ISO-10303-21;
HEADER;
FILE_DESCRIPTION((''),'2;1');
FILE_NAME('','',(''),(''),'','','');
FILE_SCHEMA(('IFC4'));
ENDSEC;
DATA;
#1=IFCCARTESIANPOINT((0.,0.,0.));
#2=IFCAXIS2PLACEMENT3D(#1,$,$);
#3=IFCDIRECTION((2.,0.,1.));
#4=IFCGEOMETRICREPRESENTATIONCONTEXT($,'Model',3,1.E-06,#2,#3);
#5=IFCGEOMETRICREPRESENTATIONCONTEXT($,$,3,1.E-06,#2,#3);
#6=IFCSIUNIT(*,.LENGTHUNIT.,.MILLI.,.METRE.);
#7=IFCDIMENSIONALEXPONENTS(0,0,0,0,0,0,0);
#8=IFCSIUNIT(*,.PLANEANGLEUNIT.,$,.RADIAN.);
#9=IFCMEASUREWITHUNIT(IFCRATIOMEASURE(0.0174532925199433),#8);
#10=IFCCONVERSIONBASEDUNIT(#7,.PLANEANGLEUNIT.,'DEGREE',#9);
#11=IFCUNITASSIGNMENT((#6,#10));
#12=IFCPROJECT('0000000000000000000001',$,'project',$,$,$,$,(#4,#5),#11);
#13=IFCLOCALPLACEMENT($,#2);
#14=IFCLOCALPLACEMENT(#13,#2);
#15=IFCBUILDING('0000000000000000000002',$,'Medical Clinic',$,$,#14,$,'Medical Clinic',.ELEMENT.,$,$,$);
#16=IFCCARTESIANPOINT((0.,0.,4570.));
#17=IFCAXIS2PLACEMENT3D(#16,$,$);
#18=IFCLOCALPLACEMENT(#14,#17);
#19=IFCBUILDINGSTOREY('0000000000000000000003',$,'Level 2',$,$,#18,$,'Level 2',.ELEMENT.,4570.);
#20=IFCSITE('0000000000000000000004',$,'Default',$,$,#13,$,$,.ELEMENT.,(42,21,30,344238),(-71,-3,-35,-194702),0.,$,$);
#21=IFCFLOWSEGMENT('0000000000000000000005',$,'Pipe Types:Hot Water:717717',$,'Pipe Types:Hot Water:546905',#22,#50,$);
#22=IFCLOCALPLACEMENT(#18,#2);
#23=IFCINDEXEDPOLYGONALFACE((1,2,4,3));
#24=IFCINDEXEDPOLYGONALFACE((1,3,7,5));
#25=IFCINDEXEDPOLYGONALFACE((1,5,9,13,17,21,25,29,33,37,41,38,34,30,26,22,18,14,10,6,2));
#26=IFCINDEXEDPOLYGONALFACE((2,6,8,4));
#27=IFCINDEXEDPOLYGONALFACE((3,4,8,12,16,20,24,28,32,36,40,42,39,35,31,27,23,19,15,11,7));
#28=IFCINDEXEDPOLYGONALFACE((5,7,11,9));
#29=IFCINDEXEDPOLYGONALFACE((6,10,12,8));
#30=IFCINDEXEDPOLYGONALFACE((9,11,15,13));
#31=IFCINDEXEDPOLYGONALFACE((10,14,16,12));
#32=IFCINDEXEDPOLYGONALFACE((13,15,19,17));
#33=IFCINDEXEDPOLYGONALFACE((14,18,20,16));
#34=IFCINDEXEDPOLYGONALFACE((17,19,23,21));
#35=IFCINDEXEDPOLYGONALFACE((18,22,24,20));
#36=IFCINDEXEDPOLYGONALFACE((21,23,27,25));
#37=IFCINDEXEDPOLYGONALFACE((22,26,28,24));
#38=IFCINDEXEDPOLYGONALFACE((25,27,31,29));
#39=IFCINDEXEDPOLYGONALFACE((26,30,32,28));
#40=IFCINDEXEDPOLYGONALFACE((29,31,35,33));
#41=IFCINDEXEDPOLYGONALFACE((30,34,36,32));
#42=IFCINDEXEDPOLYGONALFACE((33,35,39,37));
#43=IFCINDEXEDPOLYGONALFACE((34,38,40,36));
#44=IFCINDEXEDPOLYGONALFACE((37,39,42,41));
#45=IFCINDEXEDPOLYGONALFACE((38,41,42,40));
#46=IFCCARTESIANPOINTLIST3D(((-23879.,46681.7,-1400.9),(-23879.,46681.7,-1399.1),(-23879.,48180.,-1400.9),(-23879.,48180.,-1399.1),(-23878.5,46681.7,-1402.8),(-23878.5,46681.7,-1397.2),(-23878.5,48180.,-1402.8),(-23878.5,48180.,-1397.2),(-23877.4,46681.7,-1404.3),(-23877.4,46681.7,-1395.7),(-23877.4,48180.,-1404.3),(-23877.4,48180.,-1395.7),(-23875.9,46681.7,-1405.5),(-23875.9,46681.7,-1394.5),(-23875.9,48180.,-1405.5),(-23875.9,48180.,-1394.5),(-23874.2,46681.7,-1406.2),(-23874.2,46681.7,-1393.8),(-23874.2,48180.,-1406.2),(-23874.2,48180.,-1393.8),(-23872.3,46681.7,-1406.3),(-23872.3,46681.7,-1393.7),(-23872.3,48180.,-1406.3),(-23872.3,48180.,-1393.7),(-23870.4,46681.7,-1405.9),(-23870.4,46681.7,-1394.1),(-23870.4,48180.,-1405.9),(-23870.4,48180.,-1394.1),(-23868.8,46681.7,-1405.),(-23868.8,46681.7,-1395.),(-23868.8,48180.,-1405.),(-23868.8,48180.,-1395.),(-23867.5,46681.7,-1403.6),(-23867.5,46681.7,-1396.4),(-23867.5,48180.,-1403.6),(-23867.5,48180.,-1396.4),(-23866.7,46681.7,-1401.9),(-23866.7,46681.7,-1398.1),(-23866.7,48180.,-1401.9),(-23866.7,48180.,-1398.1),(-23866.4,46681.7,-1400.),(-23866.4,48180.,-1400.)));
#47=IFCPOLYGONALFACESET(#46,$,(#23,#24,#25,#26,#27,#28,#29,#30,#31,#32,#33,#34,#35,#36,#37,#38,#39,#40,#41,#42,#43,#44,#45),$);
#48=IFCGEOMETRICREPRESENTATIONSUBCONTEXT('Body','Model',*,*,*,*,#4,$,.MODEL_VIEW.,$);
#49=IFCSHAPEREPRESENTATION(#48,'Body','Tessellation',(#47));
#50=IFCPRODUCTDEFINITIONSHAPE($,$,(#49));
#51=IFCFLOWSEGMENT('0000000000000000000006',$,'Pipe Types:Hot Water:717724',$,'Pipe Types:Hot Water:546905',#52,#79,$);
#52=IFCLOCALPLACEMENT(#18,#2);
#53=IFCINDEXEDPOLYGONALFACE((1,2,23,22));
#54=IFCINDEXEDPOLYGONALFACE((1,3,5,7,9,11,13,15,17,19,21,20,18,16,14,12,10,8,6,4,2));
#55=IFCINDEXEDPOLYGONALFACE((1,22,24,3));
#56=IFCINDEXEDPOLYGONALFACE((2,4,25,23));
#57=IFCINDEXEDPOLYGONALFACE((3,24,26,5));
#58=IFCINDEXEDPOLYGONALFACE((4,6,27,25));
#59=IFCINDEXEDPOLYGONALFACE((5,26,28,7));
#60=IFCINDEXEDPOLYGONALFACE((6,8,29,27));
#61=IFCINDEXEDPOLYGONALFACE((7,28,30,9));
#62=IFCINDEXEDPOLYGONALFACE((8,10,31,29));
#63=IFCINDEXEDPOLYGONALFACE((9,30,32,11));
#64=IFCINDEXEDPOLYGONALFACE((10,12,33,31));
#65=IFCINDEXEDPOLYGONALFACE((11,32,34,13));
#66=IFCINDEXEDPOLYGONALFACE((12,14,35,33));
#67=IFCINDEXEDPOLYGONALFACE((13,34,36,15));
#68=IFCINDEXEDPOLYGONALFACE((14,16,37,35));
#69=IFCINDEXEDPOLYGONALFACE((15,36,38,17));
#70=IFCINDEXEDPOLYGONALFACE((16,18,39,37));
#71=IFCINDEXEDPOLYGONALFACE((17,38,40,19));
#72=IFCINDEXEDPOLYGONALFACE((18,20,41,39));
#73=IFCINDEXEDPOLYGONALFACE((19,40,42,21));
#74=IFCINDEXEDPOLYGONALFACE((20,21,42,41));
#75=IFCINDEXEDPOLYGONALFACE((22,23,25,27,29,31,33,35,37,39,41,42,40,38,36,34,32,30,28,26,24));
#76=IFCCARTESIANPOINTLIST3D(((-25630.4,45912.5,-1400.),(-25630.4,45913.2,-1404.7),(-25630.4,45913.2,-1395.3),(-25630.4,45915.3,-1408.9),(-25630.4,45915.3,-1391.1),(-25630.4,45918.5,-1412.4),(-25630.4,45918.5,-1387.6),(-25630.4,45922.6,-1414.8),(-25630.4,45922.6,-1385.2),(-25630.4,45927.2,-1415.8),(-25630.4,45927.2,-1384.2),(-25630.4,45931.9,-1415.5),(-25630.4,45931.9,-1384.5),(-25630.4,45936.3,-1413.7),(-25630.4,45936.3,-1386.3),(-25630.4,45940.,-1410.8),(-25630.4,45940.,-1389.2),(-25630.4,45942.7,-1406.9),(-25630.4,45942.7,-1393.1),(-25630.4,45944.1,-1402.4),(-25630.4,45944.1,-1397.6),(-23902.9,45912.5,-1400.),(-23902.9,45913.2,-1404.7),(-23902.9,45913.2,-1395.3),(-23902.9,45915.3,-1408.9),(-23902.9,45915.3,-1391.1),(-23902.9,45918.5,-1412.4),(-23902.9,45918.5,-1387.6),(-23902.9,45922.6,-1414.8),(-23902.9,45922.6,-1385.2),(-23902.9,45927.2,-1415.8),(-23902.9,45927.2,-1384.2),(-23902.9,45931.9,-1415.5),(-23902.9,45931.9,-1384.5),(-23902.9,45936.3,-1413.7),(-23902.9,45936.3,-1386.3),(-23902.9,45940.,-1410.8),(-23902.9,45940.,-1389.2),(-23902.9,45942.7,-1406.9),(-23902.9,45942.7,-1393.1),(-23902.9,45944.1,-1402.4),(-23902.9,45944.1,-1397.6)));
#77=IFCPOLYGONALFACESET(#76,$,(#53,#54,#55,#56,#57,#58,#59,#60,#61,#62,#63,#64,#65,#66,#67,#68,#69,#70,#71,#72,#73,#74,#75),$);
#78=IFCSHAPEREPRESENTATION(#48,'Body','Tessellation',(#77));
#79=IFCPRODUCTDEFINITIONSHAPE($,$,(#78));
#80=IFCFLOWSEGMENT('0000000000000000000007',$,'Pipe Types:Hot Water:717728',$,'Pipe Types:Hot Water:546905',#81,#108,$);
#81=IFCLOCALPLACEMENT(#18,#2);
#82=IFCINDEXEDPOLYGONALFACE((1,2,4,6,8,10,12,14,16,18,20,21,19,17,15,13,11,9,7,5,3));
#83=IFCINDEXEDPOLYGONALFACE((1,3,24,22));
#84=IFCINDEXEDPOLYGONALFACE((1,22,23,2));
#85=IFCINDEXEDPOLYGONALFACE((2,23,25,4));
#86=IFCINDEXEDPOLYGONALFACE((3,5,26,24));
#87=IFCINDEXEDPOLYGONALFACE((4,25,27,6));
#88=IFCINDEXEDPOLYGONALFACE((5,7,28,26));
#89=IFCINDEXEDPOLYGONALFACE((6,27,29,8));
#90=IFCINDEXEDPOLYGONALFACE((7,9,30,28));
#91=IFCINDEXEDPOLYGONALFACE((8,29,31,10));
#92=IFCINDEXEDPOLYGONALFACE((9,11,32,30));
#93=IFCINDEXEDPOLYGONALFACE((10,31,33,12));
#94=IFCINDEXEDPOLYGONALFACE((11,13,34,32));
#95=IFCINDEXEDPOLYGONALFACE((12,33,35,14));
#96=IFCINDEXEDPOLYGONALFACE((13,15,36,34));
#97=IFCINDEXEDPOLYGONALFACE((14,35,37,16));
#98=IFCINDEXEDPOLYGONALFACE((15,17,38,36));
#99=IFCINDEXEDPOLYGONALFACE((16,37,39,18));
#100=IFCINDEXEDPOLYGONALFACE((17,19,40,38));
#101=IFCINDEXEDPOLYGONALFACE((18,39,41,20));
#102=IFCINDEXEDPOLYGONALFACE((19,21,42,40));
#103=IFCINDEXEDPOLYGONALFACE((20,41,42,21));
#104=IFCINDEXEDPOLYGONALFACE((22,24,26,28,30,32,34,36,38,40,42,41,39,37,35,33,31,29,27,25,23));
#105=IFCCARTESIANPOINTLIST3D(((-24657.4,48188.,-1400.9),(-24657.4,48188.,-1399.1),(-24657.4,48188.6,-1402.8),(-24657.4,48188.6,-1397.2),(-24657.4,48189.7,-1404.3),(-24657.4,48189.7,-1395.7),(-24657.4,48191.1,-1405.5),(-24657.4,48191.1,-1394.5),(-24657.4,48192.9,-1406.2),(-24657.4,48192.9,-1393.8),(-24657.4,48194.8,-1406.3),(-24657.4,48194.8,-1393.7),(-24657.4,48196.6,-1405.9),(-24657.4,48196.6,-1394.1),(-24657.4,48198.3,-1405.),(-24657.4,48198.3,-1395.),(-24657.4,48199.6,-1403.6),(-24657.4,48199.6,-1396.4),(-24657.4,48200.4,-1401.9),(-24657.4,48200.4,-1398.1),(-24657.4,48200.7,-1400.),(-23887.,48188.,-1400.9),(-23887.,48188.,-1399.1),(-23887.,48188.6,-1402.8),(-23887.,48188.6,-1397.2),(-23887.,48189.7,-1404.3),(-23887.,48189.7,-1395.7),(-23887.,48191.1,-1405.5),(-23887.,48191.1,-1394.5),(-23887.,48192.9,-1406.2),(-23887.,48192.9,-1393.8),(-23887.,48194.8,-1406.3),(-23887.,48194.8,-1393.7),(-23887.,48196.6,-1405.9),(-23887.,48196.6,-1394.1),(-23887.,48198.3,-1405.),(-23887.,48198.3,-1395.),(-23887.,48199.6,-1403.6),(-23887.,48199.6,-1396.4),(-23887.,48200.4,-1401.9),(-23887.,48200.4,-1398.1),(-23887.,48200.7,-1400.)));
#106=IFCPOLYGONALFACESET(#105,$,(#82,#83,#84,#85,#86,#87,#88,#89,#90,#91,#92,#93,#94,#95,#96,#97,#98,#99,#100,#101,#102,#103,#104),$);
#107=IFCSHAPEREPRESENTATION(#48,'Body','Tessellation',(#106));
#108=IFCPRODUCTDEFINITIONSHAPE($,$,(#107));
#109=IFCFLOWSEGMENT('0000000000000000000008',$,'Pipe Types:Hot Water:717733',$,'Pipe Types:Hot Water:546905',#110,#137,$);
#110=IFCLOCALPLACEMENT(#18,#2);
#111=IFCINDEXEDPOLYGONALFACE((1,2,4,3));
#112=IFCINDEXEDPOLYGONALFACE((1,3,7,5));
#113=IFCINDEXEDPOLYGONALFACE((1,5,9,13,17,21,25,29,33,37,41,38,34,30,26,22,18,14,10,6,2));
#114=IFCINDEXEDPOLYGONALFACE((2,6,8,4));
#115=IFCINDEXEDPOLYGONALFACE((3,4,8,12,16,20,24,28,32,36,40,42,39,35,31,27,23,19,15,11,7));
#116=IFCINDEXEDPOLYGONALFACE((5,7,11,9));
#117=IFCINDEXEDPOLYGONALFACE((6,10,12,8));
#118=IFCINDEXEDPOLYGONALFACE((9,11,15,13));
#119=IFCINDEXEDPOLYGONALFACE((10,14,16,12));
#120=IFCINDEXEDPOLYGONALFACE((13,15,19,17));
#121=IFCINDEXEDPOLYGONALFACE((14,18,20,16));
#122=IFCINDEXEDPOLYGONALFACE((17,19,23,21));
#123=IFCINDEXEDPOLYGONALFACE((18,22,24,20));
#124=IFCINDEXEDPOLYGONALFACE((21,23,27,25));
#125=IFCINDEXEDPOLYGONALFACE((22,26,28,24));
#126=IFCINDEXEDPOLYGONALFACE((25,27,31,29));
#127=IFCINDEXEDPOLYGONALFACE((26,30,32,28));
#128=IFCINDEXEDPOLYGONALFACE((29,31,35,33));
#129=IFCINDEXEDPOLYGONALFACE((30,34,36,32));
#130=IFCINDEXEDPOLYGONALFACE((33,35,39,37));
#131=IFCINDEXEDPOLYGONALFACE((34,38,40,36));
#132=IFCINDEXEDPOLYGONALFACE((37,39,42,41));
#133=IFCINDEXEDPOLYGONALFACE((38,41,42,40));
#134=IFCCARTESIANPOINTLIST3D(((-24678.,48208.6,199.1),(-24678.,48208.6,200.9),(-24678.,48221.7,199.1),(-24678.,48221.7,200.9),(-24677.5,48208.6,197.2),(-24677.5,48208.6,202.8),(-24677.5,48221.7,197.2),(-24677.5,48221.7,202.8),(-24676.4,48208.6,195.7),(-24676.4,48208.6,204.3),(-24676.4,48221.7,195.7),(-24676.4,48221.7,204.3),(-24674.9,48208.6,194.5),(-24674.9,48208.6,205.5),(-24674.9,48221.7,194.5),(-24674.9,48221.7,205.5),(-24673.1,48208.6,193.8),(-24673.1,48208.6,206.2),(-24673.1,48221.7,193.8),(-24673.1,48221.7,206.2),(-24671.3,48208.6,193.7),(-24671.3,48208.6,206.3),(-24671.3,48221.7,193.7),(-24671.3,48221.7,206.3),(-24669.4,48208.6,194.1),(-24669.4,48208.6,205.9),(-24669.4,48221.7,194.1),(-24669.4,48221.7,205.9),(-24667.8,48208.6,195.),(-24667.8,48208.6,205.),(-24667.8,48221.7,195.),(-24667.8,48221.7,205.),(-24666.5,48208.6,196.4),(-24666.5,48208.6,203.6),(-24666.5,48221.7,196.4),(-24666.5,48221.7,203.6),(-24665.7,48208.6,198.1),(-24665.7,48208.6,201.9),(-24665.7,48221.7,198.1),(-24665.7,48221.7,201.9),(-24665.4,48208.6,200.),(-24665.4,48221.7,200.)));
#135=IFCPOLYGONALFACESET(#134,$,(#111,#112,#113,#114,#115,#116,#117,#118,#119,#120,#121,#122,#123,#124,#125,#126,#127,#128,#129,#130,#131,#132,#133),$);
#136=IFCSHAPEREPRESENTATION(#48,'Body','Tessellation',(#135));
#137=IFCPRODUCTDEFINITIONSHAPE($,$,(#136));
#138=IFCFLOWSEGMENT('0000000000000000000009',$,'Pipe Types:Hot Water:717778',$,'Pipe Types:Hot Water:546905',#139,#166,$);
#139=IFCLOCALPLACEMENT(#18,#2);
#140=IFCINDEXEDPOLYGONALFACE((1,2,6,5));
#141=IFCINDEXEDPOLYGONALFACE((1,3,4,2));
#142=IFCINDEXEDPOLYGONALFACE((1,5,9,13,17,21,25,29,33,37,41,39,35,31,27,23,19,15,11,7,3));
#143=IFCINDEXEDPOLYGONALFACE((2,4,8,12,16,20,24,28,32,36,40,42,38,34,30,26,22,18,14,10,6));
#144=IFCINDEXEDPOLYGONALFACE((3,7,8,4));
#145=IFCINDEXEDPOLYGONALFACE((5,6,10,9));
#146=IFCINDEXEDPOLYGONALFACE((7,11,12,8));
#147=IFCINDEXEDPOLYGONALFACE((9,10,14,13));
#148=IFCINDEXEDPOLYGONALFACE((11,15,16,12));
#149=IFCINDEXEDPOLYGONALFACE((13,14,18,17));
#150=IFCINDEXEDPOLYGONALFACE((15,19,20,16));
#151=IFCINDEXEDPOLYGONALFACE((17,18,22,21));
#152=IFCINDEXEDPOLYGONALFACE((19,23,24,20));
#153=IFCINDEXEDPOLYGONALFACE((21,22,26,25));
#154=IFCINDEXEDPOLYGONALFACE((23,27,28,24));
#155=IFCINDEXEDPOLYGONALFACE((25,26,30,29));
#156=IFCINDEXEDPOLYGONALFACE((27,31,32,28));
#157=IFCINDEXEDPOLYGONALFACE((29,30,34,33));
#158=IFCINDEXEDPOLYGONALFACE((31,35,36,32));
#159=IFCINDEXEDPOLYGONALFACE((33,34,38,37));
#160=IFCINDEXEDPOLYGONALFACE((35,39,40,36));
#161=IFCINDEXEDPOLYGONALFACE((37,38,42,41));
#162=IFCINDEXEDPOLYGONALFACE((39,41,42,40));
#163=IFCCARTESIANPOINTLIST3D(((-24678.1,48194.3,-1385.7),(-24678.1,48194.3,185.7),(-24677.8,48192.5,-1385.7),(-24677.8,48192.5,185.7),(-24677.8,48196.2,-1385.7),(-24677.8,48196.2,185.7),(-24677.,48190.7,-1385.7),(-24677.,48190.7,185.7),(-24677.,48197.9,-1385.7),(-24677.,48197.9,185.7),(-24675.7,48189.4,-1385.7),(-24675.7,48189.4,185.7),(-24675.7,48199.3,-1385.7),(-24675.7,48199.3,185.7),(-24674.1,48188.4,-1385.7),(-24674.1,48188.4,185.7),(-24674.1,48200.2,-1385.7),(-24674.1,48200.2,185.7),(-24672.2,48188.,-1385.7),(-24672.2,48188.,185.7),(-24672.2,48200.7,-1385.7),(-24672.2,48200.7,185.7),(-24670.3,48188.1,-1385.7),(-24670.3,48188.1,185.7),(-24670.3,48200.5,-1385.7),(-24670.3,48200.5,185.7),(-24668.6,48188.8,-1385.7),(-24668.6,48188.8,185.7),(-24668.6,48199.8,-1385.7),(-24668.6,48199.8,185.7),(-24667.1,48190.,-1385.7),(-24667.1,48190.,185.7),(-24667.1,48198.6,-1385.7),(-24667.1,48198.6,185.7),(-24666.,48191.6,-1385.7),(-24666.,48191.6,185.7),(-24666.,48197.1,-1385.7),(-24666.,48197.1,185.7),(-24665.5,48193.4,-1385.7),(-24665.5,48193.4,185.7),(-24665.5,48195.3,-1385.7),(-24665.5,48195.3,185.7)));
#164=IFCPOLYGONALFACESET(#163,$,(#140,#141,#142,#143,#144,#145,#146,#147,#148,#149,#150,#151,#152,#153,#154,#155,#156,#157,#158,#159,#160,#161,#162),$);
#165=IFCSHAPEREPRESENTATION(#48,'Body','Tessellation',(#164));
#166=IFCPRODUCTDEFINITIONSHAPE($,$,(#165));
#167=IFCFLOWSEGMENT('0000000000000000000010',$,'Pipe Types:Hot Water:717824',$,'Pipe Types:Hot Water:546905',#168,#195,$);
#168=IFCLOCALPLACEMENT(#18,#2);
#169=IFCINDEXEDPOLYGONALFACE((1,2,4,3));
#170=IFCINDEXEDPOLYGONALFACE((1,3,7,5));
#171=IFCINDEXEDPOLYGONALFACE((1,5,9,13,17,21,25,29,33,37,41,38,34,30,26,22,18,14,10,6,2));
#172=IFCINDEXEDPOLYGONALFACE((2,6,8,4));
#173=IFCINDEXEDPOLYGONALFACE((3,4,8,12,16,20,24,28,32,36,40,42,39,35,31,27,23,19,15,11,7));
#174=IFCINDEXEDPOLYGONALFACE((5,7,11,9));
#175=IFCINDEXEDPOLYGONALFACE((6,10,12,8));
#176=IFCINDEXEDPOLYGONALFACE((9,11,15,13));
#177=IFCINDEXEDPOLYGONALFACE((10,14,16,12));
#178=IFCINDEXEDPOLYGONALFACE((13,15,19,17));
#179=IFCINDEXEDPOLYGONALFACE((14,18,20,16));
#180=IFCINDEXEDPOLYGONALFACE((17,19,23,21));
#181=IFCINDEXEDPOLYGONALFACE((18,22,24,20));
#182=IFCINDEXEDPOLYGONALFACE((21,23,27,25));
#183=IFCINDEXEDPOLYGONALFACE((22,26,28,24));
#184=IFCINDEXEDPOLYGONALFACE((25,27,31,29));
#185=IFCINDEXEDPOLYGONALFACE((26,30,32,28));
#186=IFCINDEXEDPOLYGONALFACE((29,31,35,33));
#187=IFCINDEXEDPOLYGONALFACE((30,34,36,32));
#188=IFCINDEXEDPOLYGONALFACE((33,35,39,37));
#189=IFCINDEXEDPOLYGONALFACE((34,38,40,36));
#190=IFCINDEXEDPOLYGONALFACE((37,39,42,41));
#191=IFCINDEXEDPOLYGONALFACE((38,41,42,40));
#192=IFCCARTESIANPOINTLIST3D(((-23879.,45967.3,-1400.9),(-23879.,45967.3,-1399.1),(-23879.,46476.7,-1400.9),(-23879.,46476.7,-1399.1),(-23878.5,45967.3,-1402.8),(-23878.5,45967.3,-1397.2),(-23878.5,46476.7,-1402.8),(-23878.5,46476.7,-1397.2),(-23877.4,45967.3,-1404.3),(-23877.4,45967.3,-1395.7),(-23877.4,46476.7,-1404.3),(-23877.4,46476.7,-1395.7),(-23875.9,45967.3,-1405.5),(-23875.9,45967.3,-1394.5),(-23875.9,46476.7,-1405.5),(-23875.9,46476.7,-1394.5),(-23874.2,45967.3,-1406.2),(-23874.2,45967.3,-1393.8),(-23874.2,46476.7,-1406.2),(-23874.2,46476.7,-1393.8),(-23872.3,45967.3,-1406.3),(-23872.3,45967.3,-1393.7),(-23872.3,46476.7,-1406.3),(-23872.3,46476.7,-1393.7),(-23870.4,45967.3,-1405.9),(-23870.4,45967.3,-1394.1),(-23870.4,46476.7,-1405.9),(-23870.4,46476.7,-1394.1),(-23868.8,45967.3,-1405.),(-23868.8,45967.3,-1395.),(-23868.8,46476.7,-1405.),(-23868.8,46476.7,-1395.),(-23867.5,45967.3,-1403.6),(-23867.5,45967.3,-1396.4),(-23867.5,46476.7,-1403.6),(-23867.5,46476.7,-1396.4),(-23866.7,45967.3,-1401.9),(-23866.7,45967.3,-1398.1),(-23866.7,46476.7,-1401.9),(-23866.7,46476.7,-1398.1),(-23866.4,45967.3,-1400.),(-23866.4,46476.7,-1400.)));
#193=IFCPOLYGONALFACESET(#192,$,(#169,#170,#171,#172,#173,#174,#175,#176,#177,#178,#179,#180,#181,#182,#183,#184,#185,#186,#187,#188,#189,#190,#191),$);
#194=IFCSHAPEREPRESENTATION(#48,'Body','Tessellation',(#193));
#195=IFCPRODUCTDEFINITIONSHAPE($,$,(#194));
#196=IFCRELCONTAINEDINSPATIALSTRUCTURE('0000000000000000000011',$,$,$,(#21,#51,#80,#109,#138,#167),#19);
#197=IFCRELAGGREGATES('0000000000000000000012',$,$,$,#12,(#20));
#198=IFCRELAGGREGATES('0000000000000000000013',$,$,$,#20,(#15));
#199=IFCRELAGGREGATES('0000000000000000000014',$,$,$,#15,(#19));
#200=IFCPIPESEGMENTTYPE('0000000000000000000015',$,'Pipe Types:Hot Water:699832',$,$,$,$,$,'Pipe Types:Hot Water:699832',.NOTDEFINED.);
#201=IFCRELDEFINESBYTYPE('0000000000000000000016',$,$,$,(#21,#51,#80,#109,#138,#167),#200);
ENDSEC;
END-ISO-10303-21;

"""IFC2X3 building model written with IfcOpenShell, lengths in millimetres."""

from ifc_helpers import new_model, entity, si_unit, converted_unit, direction, frame, frame_2d, origin, origin_2d_with_axis, place, context, subcontext, project, spatial, circle, extrude, type_object, element, save


model = new_model("IFC2X3")

# Units and contexts
model_context = context("Model", 3, precision=1e-06, world=origin(), true_north=direction((2.0, 0.0, 1.0)))
context_of_model = context(None, 3, precision=1e-06, world=origin(), true_north=direction((2.0, 0.0, 1.0)))
body_context = subcontext(model_context, "Body", "Model", "MODEL_VIEW")
ifc_project = project(units=[si_unit("LENGTHUNIT", "METRE", prefix="MILLI"), converted_unit("PLANEANGLEUNIT", "DEGREE", entity("IfcRatioMeasure", 0.0174532925199433), si_unit("PLANEANGLEUNIT", "RADIAN"), dimensions=[0, 0, 0, 0, 0, 0, 0])], contexts=[model_context, context_of_model])

# Site, building, storey
site_placement = place(None, origin())
site = spatial("IfcSite", under=ifc_project, at=site_placement, Name="Default", CompositionType="ELEMENT", RefLatitude=(42, 21, 30, 344238), RefLongitude=(-71, -3, -35, -194702), RefElevation=0.0)
building_placement = place(site_placement, origin())
building = spatial("IfcBuilding", under=site, at=building_placement, Name="Medical Clinic", LongName="Medical Clinic", CompositionType="ELEMENT")
storey_placement = place(building_placement, frame((0.0, 0.0, 4570.0)))
storey = spatial("IfcBuildingStorey", under=building, at=storey_placement, Name="Level 2", LongName="Level 2", CompositionType="ELEMENT", Elevation=4570.0)

# Flow segments
pipe_segment_type = type_object("IfcPipeSegmentType", Name="Pipe Types:Hot Water:699832", ElementType="Pipe Types:Hot Water:699832", PredefinedType="NOTDEFINED")
flow_segment_1_placement = place(storey_placement, origin())
element("IfcFlowSegment", 1, at=flow_segment_1_placement, inside=storey, type_object=pipe_segment_type, Name="Pipe Types:Hot Water:717717", ObjectType="Pipe Types:Hot Water:546905", context=body_context, shape_type="SweptSolid", body=[
    extrude(circle(Radius=6.3, at=origin_2d_with_axis()), frame((-23872.7, 46681.7, -1400.0), z_axis=(0.0, 1.0, 0.0), x_axis=(1.0, 0.0, 0.0)), (0.0, 0.0, 1.0), 1498.4),
])
flow_segment_2_placement = place(storey_placement, origin())
element("IfcFlowSegment", 2, at=flow_segment_2_placement, inside=storey, type_object=pipe_segment_type, Name="Pipe Types:Hot Water:717724", ObjectType="Pipe Types:Hot Water:546905", context=body_context, shape_type="SweptSolid", body=[
    extrude(circle(Radius=15.9, at=origin_2d_with_axis()), frame((-25630.4, 45928.4, -1400.0), z_axis=(1.0, 0.0, 0.0), x_axis=(0.0, -1.0, 0.0)), (0.0, 0.0, 1.0), 1727.4),
])
flow_segment_3_placement = place(storey_placement, origin())
element("IfcFlowSegment", 3, at=flow_segment_3_placement, inside=storey, type_object=pipe_segment_type, Name="Pipe Types:Hot Water:717728", ObjectType="Pipe Types:Hot Water:546905", context=body_context, shape_type="SweptSolid", body=[
    extrude(circle(Radius=6.3, at=frame_2d((0.0, 0.0), x_axis=(1.0, 0.0))), frame((-24657.4, 48194.3, -1400.0), z_axis=(1.0, 0.0, 0.0), x_axis=(0.0, 1.0, 0.0)), (0.0, 0.0, 1.0), 770.4),
])
flow_segment_4_placement = place(storey_placement, origin())
element("IfcFlowSegment", 4, at=flow_segment_4_placement, inside=storey, type_object=pipe_segment_type, Name="Pipe Types:Hot Water:717733", ObjectType="Pipe Types:Hot Water:546905", context=body_context, shape_type="SweptSolid", body=[
    extrude(circle(Radius=6.3, at=origin_2d_with_axis()), frame((-24671.7, 48208.6, 200.0), z_axis=(0.0, 1.0, 0.0), x_axis=(1.0, 0.0, 0.0)), (0.0, 0.0, 1.0), 13.1),
])
flow_segment_5_placement = place(storey_placement, origin())
element("IfcFlowSegment", 5, at=flow_segment_5_placement, inside=storey, type_object=pipe_segment_type, Name="Pipe Types:Hot Water:717778", ObjectType="Pipe Types:Hot Water:546905", context=body_context, shape_type="SweptSolid", body=[
    extrude(circle(Radius=6.3, at=origin_2d_with_axis()), frame((-24671.7, 48194.3, -1385.7), z_axis=(0.0, 0.0, 1.0), x_axis=(-1.0, 0.0, 0.0)), (0.0, 0.0, 1.0), 1571.4),
])
flow_segment_6_placement = place(storey_placement, origin())
element("IfcFlowSegment", 6, at=flow_segment_6_placement, inside=storey, type_object=pipe_segment_type, Name="Pipe Types:Hot Water:717824", ObjectType="Pipe Types:Hot Water:546905", context=body_context, shape_type="SweptSolid", body=[
    extrude(circle(Radius=6.3, at=origin_2d_with_axis()), frame((-23872.7, 45967.3, -1400.0), z_axis=(0.0, 1.0, 0.0), x_axis=(1.0, 0.0, 0.0)), (0.0, 0.0, 1.0), 509.4),
])

save(model, "model.ifc")
